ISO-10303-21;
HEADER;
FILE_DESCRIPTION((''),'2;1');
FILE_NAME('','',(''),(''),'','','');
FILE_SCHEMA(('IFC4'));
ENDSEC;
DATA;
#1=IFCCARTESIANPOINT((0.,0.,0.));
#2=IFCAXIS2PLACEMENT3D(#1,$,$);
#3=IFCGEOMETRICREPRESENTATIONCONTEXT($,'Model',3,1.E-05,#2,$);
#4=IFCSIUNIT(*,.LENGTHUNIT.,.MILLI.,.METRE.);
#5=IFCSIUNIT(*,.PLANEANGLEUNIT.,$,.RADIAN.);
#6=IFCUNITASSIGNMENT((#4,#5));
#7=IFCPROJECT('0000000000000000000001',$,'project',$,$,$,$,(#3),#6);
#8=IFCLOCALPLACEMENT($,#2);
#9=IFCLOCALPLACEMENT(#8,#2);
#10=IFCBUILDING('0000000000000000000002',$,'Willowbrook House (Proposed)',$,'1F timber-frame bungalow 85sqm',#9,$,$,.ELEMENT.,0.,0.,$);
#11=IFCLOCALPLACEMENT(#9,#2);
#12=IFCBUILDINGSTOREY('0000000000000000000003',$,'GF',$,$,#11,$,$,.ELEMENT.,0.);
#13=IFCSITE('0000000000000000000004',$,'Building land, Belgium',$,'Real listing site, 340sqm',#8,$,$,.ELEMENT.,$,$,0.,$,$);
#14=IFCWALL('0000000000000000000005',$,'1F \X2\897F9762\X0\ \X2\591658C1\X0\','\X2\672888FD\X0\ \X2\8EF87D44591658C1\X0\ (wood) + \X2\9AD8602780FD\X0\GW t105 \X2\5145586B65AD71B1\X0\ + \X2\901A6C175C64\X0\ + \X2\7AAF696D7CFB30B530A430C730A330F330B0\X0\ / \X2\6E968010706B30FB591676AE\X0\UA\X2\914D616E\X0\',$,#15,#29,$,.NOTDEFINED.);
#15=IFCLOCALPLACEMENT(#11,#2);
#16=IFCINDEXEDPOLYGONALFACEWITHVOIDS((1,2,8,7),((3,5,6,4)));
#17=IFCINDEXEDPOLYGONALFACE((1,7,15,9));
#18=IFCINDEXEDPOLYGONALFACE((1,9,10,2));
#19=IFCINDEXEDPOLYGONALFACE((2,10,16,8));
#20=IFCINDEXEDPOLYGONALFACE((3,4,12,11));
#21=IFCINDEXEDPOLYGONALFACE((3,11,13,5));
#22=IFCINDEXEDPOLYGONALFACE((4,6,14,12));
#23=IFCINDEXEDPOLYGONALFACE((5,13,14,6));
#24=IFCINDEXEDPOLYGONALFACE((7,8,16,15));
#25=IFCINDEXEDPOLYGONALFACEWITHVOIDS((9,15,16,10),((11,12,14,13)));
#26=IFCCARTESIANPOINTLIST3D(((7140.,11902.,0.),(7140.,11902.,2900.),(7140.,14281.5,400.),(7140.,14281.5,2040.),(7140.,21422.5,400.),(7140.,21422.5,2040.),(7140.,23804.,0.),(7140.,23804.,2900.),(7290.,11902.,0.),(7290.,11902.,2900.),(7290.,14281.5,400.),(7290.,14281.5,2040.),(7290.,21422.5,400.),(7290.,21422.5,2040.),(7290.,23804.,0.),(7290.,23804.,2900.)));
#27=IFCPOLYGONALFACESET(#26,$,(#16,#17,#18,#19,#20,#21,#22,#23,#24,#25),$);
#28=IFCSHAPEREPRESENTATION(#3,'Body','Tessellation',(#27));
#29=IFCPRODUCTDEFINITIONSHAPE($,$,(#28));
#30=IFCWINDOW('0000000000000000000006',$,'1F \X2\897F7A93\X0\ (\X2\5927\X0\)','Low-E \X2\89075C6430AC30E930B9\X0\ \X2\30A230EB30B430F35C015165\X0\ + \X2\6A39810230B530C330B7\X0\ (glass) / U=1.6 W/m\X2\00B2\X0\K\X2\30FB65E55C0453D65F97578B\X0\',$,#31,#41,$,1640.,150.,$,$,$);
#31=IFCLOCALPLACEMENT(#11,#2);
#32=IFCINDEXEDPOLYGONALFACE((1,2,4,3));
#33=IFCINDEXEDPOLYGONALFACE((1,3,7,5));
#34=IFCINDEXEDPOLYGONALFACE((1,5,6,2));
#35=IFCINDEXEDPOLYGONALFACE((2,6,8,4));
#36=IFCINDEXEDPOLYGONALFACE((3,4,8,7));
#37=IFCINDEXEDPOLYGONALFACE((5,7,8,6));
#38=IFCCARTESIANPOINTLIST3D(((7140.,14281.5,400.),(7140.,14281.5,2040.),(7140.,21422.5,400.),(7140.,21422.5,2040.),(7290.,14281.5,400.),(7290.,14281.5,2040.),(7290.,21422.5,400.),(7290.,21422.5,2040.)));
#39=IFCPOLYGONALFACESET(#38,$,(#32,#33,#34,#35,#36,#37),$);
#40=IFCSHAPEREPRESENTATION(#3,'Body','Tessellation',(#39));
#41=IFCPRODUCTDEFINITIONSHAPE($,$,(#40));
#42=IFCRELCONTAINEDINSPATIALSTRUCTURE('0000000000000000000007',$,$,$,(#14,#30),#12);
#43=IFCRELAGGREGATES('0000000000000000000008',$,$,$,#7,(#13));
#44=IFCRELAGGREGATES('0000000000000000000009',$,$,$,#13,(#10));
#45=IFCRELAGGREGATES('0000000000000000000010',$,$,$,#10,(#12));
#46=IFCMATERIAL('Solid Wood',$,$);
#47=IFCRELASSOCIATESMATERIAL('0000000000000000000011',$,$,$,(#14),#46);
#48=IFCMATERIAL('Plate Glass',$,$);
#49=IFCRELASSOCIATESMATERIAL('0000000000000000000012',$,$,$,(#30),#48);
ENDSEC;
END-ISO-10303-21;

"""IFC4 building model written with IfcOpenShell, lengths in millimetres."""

from ifc_helpers import new_model, si_unit, frame, frame_2d, origin, place, context, project, spatial, rectangle, extrude, material, element, fill, save


model = new_model("IFC4")

# Units and contexts
model_context = context("Model", 3, precision=1e-05, world=origin())
ifc_project = project(units=[si_unit("LENGTHUNIT", "METRE", prefix="MILLI"), si_unit("PLANEANGLEUNIT", "RADIAN")], contexts=[model_context])

# Site, building, storey
site_placement = place(None, origin())
site = spatial("IfcSite", under=ifc_project, at=site_placement, Name="Building land, Belgium", ObjectType="Real listing site, 340sqm", CompositionType="ELEMENT", RefElevation=0.0)
building_placement = place(site_placement, origin())
building = spatial("IfcBuilding", under=site, at=building_placement, Name="Willowbrook House (Proposed)", ObjectType="1F timber-frame bungalow 85sqm", CompositionType="ELEMENT", ElevationOfRefHeight=0.0, ElevationOfTerrain=0.0)
storey_placement = place(building_placement, origin())
storey = spatial("IfcBuildingStorey", under=building, at=storey_placement, Name="GF", CompositionType="ELEMENT", Elevation=0.0)

# Shared definitions
ifc_material_1 = material(Name="Solid Wood")

# Shared definitions
ifc_material_2 = material(Name="Plate Glass")

# Wall, opening, window
wall_1_placement = place(storey_placement, frame((3570.0, 5951.0, 0.0)))
wall_1 = element("IfcWall", 1, at=wall_1_placement, inside=storey, material=ifc_material_1, Name="1F 西面 外壁", Description="木製 軸組外壁 (wood) + 高性能GW t105 充填断熱 + 通気層 + 窯業系サイディング / 準耐火・外皮UA配慮", PredefinedType="NOTDEFINED", context=model_context, shape_type="SweptSolid", body=[
    extrude(rectangle(XDim=150.0, YDim=11902.0, at=frame_2d((75.0, 5951.0))), frame((3570.0, 5951.0, 0.0)), (0.0, 0.0, 1.0), 2900.0),
])
opening_1_placement = place(storey_placement, frame((3570.0, 7141.0, 200.0)))
opening_1 = element("IfcOpeningElement", 2, at=opening_1_placement, cuts=wall_1, PredefinedType="NOTDEFINED", context=model_context, shape_type="SweptSolid", body=[
    extrude(rectangle(XDim=150.0, YDim=7141.0, at=frame_2d((75.0, 3570.0))), frame((3570.0, 7141.0, 200.0)), (0.0, 0.0, 1.0), 1640.0),
])
window_1_placement = place(storey_placement, frame((3570.0, 7141.0, 200.0)))
window_1 = element("IfcWindow", 3, at=window_1_placement, inside=storey, material=ifc_material_2, Name="1F 西窓 (大)", Description="Low-E 複層ガラス アルゴン封入 + 樹脂サッシ (glass) / U=1.6 W/m²K・日射取得型", OverallHeight=1640.0, OverallWidth=150.0, context=model_context, shape_type="SweptSolid", body=[
    extrude(rectangle(XDim=150.0, YDim=7141.0, at=frame_2d((75.0, 3570.0))), frame((3570.0, 7141.0, 200.0)), (0.0, 0.0, 1.0), 1640.0),
])
fill(opening_1, window_1)

save(model, "model.ifc")
